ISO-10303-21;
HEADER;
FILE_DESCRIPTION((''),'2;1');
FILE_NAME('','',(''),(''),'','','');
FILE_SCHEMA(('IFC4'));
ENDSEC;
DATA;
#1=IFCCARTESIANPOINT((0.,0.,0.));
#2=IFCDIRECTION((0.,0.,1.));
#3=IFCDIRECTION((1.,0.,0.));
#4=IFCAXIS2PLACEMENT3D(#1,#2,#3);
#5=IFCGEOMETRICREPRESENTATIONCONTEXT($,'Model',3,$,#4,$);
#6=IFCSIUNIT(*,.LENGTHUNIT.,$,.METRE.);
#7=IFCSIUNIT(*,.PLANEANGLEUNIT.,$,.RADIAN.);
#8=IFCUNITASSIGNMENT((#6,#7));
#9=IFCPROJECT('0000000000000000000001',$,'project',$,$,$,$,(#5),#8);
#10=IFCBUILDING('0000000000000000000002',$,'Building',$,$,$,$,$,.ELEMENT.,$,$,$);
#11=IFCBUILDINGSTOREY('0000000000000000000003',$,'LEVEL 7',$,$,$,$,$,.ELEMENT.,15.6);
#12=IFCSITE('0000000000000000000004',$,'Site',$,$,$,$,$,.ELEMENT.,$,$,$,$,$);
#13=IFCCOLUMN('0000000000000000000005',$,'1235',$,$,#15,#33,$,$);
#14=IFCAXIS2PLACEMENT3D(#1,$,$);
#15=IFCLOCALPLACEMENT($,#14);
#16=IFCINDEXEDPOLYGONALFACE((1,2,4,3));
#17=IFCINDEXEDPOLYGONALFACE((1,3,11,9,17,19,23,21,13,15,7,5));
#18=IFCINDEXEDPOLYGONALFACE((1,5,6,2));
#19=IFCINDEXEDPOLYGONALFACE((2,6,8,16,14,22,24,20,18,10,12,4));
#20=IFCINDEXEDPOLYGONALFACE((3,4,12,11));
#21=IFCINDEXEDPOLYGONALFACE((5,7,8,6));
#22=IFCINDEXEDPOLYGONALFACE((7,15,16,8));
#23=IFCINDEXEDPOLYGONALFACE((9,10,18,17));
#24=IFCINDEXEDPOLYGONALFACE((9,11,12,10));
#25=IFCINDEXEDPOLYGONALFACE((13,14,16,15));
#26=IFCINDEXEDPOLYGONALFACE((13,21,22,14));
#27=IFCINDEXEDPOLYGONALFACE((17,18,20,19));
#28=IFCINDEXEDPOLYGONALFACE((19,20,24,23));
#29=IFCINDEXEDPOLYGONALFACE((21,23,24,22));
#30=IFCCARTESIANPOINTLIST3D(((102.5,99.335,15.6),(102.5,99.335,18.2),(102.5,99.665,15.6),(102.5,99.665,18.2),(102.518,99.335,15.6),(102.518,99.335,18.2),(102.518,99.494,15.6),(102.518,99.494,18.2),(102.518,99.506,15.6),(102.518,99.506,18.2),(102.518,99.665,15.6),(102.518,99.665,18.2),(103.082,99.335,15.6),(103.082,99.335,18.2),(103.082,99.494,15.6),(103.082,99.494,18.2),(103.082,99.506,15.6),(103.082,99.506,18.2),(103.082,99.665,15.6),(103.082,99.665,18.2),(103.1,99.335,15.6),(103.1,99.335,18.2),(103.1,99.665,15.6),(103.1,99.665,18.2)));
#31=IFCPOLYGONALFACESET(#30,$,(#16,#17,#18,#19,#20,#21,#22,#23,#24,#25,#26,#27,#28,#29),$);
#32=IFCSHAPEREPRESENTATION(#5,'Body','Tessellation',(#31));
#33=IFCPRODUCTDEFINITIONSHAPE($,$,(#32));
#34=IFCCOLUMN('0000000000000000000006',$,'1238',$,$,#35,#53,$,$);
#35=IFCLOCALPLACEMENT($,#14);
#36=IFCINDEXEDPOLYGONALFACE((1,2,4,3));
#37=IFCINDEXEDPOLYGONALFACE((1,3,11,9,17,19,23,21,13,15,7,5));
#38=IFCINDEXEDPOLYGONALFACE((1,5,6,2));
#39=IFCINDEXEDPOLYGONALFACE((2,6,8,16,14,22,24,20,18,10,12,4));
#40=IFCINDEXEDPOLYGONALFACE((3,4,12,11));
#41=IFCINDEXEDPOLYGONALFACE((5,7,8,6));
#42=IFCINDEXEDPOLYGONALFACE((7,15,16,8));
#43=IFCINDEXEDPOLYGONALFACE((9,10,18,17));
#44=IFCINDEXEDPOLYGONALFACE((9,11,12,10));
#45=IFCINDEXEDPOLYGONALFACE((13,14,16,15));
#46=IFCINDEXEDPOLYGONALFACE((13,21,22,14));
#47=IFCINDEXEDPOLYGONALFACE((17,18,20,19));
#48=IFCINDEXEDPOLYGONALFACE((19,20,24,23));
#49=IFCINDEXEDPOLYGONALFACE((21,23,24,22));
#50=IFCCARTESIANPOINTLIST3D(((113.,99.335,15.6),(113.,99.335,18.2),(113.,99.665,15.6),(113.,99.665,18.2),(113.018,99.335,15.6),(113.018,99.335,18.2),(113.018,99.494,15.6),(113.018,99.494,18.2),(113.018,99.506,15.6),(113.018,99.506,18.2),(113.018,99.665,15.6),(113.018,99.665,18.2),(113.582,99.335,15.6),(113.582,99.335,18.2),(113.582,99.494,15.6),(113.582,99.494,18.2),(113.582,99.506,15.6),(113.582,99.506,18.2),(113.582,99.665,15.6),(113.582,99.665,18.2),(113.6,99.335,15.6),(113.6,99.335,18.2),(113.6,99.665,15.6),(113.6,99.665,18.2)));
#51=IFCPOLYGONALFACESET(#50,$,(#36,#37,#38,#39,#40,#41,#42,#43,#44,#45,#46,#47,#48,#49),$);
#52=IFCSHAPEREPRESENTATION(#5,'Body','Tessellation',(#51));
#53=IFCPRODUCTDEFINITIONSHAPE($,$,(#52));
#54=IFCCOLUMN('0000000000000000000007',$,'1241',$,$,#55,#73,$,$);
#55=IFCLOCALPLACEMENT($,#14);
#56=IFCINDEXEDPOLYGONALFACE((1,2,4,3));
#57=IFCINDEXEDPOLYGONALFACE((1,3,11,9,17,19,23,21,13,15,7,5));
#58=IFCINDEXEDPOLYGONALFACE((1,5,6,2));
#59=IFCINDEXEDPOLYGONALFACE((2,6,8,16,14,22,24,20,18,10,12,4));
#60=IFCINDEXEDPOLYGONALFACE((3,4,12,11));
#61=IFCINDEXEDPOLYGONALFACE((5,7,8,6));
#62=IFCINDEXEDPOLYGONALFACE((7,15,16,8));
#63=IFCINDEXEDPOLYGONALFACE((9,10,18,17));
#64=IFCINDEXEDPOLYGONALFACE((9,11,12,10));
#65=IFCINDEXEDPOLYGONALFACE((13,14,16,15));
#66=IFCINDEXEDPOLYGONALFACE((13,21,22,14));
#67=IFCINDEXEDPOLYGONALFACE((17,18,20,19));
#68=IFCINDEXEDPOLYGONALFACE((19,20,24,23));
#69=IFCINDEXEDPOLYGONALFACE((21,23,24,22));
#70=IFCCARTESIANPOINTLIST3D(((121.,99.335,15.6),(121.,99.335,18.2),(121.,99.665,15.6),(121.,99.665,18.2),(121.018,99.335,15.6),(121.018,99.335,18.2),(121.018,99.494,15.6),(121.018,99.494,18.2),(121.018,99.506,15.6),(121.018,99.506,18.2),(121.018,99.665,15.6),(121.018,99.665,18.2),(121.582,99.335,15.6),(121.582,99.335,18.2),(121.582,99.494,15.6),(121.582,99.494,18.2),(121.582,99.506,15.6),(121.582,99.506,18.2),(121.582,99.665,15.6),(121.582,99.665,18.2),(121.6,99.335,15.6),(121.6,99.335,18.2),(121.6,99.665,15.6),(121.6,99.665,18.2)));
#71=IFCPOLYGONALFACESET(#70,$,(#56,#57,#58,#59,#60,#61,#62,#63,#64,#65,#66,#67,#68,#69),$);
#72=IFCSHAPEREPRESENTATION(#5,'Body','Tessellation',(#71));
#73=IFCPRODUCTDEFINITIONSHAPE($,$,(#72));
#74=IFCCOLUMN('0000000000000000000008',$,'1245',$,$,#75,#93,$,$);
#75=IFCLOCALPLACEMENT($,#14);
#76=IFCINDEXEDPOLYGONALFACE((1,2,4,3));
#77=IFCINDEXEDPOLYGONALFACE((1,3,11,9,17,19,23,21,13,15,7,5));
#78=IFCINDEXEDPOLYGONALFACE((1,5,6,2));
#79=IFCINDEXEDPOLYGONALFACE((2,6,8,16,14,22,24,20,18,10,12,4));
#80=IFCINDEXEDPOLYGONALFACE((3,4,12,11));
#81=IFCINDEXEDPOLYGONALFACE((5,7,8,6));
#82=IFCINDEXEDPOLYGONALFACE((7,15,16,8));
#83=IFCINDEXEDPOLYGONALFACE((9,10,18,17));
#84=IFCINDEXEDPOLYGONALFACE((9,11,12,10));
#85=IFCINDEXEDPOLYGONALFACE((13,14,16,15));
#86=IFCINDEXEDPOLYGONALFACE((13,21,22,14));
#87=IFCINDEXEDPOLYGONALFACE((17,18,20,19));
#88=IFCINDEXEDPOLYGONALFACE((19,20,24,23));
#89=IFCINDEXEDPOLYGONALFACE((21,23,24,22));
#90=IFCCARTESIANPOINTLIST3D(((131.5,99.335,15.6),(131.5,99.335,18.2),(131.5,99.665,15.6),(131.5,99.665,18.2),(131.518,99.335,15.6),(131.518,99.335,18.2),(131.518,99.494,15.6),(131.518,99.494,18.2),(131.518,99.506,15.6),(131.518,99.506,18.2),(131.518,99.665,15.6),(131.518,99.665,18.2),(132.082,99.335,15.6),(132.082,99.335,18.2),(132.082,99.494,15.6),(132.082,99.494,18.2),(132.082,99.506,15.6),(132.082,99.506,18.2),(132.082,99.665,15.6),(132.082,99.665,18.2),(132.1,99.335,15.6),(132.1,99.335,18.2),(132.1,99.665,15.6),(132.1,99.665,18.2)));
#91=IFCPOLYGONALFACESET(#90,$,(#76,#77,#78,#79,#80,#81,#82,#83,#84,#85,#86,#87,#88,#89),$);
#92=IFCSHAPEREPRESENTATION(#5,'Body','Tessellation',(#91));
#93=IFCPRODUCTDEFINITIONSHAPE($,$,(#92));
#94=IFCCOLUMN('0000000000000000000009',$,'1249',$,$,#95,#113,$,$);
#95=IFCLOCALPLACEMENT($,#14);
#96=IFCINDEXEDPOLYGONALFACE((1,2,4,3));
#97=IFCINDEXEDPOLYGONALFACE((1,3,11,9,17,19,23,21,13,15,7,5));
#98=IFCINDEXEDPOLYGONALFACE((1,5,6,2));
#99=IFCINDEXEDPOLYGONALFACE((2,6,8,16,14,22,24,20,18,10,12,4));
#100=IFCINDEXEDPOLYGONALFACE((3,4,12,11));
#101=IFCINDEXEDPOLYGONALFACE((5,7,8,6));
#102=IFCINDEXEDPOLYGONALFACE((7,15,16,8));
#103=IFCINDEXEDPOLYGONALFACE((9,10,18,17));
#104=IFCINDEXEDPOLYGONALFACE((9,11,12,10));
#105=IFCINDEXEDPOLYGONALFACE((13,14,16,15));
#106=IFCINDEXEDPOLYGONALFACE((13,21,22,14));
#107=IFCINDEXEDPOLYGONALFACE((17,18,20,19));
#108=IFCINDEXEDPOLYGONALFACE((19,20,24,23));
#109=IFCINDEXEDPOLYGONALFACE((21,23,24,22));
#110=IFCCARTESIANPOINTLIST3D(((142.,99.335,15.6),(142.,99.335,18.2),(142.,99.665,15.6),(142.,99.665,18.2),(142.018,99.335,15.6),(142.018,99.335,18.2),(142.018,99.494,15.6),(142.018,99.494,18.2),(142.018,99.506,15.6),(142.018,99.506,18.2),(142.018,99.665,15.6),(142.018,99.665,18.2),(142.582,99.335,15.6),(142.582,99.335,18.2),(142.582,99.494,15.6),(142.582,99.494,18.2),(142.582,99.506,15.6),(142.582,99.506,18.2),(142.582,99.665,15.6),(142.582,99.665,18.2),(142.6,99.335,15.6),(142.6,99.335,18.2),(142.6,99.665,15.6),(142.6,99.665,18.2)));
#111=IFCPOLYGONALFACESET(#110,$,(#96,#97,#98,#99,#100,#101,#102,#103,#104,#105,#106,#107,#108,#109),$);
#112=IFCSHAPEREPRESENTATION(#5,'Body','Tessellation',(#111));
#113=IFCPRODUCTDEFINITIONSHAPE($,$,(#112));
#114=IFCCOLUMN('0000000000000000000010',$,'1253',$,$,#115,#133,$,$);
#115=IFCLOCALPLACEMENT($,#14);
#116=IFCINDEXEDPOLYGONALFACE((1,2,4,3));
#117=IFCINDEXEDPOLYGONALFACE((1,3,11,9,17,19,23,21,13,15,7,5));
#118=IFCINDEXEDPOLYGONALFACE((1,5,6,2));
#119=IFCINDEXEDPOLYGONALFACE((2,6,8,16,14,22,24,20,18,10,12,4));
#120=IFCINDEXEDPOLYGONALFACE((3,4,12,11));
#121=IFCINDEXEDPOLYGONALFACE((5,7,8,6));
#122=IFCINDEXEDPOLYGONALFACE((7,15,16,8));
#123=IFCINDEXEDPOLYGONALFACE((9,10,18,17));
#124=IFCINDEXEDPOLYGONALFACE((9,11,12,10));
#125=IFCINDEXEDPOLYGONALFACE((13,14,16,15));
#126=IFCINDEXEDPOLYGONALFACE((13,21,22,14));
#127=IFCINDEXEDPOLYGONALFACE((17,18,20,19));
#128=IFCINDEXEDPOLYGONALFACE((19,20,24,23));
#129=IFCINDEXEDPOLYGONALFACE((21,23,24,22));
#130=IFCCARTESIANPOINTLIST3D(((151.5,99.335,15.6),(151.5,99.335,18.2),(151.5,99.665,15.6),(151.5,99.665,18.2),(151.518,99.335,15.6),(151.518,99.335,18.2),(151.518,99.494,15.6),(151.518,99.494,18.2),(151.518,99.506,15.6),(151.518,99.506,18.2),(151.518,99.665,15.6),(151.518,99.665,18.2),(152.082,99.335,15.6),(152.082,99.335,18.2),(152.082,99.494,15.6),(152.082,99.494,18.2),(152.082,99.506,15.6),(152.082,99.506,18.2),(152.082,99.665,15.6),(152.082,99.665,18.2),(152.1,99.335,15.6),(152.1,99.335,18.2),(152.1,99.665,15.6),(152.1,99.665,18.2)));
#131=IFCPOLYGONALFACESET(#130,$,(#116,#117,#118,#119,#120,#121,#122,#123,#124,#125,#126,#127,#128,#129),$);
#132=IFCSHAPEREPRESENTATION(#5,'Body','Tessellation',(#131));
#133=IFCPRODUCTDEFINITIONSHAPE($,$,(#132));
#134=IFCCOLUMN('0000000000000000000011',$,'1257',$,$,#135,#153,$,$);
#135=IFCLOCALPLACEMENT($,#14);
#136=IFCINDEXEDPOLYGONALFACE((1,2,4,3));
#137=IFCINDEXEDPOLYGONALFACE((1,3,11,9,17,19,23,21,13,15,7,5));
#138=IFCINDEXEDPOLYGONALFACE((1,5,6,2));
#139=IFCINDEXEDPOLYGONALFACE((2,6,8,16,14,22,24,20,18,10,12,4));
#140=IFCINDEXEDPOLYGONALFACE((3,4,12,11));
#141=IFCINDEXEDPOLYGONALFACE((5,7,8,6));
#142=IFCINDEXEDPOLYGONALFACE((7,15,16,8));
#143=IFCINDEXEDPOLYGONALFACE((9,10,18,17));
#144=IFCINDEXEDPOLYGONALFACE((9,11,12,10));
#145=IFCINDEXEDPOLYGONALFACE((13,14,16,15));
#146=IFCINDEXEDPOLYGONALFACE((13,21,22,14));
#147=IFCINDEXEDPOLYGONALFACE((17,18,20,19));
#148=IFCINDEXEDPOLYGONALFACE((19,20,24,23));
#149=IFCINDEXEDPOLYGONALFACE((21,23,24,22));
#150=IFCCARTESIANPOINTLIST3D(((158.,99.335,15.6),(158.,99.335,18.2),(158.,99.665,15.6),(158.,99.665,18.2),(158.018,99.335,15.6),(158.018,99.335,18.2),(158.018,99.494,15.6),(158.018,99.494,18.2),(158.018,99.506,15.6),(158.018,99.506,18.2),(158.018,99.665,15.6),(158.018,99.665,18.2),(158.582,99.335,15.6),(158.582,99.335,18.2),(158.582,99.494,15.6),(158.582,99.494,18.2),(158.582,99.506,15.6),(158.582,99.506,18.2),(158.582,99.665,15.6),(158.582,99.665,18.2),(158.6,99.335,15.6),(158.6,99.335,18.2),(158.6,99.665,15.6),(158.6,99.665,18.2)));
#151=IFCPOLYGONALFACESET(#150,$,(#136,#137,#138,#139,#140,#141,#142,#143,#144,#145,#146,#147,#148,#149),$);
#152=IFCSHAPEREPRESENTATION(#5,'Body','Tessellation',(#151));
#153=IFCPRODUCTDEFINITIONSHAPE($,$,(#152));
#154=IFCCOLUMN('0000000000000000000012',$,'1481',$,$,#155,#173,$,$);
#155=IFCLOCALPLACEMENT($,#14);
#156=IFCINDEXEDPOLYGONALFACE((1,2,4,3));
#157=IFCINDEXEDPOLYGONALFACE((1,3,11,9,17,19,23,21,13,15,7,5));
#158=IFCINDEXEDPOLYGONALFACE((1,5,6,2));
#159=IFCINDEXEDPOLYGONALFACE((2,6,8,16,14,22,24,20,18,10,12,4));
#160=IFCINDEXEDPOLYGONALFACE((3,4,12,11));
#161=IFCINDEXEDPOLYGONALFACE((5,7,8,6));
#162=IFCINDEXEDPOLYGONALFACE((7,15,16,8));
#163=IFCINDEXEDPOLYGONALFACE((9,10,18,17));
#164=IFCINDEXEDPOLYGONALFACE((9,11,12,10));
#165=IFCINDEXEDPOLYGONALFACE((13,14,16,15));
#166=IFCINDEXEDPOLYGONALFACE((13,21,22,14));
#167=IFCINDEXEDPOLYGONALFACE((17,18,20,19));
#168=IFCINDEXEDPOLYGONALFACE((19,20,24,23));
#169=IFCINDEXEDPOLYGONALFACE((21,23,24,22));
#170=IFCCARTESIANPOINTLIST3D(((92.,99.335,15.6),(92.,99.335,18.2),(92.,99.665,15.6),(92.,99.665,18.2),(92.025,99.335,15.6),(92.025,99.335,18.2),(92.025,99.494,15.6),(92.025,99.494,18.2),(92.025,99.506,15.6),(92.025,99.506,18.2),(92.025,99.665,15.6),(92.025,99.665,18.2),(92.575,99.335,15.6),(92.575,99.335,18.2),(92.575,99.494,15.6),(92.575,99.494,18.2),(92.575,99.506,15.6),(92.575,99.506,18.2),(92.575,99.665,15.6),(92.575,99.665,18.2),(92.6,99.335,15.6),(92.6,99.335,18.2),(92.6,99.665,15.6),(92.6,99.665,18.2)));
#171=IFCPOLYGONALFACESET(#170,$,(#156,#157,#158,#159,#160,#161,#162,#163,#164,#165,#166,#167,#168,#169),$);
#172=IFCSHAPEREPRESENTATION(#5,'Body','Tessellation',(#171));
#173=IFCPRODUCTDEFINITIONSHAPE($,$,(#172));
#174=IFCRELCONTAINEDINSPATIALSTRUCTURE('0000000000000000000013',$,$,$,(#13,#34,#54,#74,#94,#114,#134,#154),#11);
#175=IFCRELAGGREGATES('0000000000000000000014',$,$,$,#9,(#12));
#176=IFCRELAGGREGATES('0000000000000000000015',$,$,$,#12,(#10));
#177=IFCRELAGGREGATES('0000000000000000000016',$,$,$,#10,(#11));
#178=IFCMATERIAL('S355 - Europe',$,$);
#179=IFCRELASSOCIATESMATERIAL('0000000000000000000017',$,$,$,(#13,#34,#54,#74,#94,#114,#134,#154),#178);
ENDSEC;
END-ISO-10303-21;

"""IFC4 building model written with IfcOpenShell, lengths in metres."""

from ifc_helpers import new_model, si_unit, frame, origin_with_axes, origin_2d_with_axis, place, context, project, spatial, i_section, extrude, material, material_profile, profile_set, profile_usage, element, save


model = new_model("IFC4")

# Units and contexts
model_context = context("Model", 3, world=origin_with_axes())
ifc_project = project(units=[si_unit("LENGTHUNIT", "METRE"), si_unit("PLANEANGLEUNIT", "RADIAN")], contexts=[model_context])

# Site, building, storey
site = spatial("IfcSite", under=ifc_project, Name="Site", CompositionType="ELEMENT")
building = spatial("IfcBuilding", under=site, Name="Building", CompositionType="ELEMENT")
storey = spatial("IfcBuildingStorey", under=building, Name="LEVEL 7", CompositionType="ELEMENT", Elevation=15.6)

# Columns
ifc_material = material(Name="S355 - Europe")
ifc_material_profile_1 = material_profile(ifc_material, i_section(OverallWidth=0.33, OverallDepth=0.6, WebThickness=0.012, FlangeThickness=0.018, at=origin_2d_with_axis()))
ifc_profile_set_1 = profile_set([ifc_material_profile_1])
ifc_profile_usage_1 = profile_usage(ifc_profile_set_1, cardinal=10)
column_1_placement = place(None, frame((102.8, 99.5, 15.6), z_axis=(0.0, 0.0, 1.0), x_axis=(0.0, -1.0, 0.0)))
element("IfcColumn", 1, at=column_1_placement, inside=storey, material=ifc_profile_usage_1, Name="1235", context=model_context, shape_type="SweptSolid", body=[
    extrude(i_section(OverallWidth=0.33, OverallDepth=0.6, WebThickness=0.012, FlangeThickness=0.018, at=origin_2d_with_axis()), origin_with_axes(), (0.0, 0.0, 1.0), 2.6),
])
ifc_material_profile_2 = material_profile(ifc_material, i_section(OverallWidth=0.33, OverallDepth=0.6, WebThickness=0.012, FlangeThickness=0.018, at=origin_2d_with_axis()))
ifc_profile_set_2 = profile_set([ifc_material_profile_2])
ifc_profile_usage_2 = profile_usage(ifc_profile_set_2, cardinal=10)
column_2_placement = place(None, frame((113.3, 99.5, 15.6), z_axis=(0.0, 0.0, 1.0), x_axis=(0.0, -1.0, 0.0)))
element("IfcColumn", 2, at=column_2_placement, inside=storey, material=ifc_profile_usage_2, Name="1238", context=model_context, shape_type="SweptSolid", body=[
    extrude(i_section(OverallWidth=0.33, OverallDepth=0.6, WebThickness=0.012, FlangeThickness=0.018, at=origin_2d_with_axis()), origin_with_axes(), (0.0, 0.0, 1.0), 2.6),
])
ifc_material_profile_3 = material_profile(ifc_material, i_section(OverallWidth=0.33, OverallDepth=0.6, WebThickness=0.012, FlangeThickness=0.018, at=origin_2d_with_axis()))
ifc_profile_set_3 = profile_set([ifc_material_profile_3])
ifc_profile_usage_3 = profile_usage(ifc_profile_set_3, cardinal=10)
column_3_placement = place(None, frame((121.3, 99.5, 15.6), z_axis=(0.0, 0.0, 1.0), x_axis=(0.0, -1.0, 0.0)))
element("IfcColumn", 3, at=column_3_placement, inside=storey, material=ifc_profile_usage_3, Name="1241", context=model_context, shape_type="SweptSolid", body=[
    extrude(i_section(OverallWidth=0.33, OverallDepth=0.6, WebThickness=0.012, FlangeThickness=0.018, at=origin_2d_with_axis()), origin_with_axes(), (0.0, 0.0, 1.0), 2.6),
])
ifc_material_profile_4 = material_profile(ifc_material, i_section(OverallWidth=0.33, OverallDepth=0.6, WebThickness=0.012, FlangeThickness=0.018, at=origin_2d_with_axis()))
ifc_profile_set_4 = profile_set([ifc_material_profile_4])
ifc_profile_usage_4 = profile_usage(ifc_profile_set_4, cardinal=10)
column_4_placement = place(None, frame((131.8, 99.5, 15.6), z_axis=(0.0, 0.0, 1.0), x_axis=(0.0, -1.0, 0.0)))
element("IfcColumn", 4, at=column_4_placement, inside=storey, material=ifc_profile_usage_4, Name="1245", context=model_context, shape_type="SweptSolid", body=[
    extrude(i_section(OverallWidth=0.33, OverallDepth=0.6, WebThickness=0.012, FlangeThickness=0.018, at=origin_2d_with_axis()), origin_with_axes(), (0.0, 0.0, 1.0), 2.6),
])
ifc_material_profile_5 = material_profile(ifc_material, i_section(OverallWidth=0.33, OverallDepth=0.6, WebThickness=0.012, FlangeThickness=0.018, at=origin_2d_with_axis()))
ifc_profile_set_5 = profile_set([ifc_material_profile_5])
ifc_profile_usage_5 = profile_usage(ifc_profile_set_5, cardinal=10)
column_5_placement = place(None, frame((142.3, 99.5, 15.6), z_axis=(0.0, 0.0, 1.0), x_axis=(0.0, -1.0, 0.0)))
element("IfcColumn", 5, at=column_5_placement, inside=storey, material=ifc_profile_usage_5, Name="1249", context=model_context, shape_type="SweptSolid", body=[
    extrude(i_section(OverallWidth=0.33, OverallDepth=0.6, WebThickness=0.012, FlangeThickness=0.018, at=origin_2d_with_axis()), origin_with_axes(), (0.0, 0.0, 1.0), 2.6),
])
ifc_material_profile_6 = material_profile(ifc_material, i_section(OverallWidth=0.33, OverallDepth=0.6, WebThickness=0.012, FlangeThickness=0.018, at=origin_2d_with_axis()))
ifc_profile_set_6 = profile_set([ifc_material_profile_6])
ifc_profile_usage_6 = profile_usage(ifc_profile_set_6, cardinal=10)
column_6_placement = place(None, frame((151.8, 99.5, 15.6), z_axis=(0.0, 0.0, 1.0), x_axis=(0.0, -1.0, 0.0)))
element("IfcColumn", 6, at=column_6_placement, inside=storey, material=ifc_profile_usage_6, Name="1253", context=model_context, shape_type="SweptSolid", body=[
    extrude(i_section(OverallWidth=0.33, OverallDepth=0.6, WebThickness=0.012, FlangeThickness=0.018, at=origin_2d_with_axis()), origin_with_axes(), (0.0, 0.0, 1.0), 2.6),
])
ifc_material_profile_7 = material_profile(ifc_material, i_section(OverallWidth=0.33, OverallDepth=0.6, WebThickness=0.012, FlangeThickness=0.018, at=origin_2d_with_axis()))
ifc_profile_set_7 = profile_set([ifc_material_profile_7])
ifc_profile_usage_7 = profile_usage(ifc_profile_set_7, cardinal=10)
column_7_placement = place(None, frame((158.3, 99.5, 15.6), z_axis=(0.0, 0.0, 1.0), x_axis=(0.0, -1.0, 0.0)))
element("IfcColumn", 7, at=column_7_placement, inside=storey, material=ifc_profile_usage_7, Name="1257", context=model_context, shape_type="SweptSolid", body=[
    extrude(i_section(OverallWidth=0.33, OverallDepth=0.6, WebThickness=0.012, FlangeThickness=0.018, at=origin_2d_with_axis()), origin_with_axes(), (0.0, 0.0, 1.0), 2.6),
])
ifc_material_profile_8 = material_profile(ifc_material, i_section(OverallWidth=0.33, OverallDepth=0.6, WebThickness=0.012, FlangeThickness=0.025, at=origin_2d_with_axis()))
ifc_profile_set_8 = profile_set([ifc_material_profile_8])
ifc_profile_usage_8 = profile_usage(ifc_profile_set_8, cardinal=10)
column_8_placement = place(None, frame((92.3, 99.5, 15.6), z_axis=(0.0, 0.0, 1.0), x_axis=(0.0, -1.0, 0.0)))
element("IfcColumn", 8, at=column_8_placement, inside=storey, material=ifc_profile_usage_8, Name="1481", context=model_context, shape_type="SweptSolid", body=[
    extrude(i_section(OverallWidth=0.33, OverallDepth=0.6, WebThickness=0.012, FlangeThickness=0.025, at=origin_2d_with_axis()), origin_with_axes(), (0.0, 0.0, 1.0), 2.6),
])

save(model, "model.ifc")
